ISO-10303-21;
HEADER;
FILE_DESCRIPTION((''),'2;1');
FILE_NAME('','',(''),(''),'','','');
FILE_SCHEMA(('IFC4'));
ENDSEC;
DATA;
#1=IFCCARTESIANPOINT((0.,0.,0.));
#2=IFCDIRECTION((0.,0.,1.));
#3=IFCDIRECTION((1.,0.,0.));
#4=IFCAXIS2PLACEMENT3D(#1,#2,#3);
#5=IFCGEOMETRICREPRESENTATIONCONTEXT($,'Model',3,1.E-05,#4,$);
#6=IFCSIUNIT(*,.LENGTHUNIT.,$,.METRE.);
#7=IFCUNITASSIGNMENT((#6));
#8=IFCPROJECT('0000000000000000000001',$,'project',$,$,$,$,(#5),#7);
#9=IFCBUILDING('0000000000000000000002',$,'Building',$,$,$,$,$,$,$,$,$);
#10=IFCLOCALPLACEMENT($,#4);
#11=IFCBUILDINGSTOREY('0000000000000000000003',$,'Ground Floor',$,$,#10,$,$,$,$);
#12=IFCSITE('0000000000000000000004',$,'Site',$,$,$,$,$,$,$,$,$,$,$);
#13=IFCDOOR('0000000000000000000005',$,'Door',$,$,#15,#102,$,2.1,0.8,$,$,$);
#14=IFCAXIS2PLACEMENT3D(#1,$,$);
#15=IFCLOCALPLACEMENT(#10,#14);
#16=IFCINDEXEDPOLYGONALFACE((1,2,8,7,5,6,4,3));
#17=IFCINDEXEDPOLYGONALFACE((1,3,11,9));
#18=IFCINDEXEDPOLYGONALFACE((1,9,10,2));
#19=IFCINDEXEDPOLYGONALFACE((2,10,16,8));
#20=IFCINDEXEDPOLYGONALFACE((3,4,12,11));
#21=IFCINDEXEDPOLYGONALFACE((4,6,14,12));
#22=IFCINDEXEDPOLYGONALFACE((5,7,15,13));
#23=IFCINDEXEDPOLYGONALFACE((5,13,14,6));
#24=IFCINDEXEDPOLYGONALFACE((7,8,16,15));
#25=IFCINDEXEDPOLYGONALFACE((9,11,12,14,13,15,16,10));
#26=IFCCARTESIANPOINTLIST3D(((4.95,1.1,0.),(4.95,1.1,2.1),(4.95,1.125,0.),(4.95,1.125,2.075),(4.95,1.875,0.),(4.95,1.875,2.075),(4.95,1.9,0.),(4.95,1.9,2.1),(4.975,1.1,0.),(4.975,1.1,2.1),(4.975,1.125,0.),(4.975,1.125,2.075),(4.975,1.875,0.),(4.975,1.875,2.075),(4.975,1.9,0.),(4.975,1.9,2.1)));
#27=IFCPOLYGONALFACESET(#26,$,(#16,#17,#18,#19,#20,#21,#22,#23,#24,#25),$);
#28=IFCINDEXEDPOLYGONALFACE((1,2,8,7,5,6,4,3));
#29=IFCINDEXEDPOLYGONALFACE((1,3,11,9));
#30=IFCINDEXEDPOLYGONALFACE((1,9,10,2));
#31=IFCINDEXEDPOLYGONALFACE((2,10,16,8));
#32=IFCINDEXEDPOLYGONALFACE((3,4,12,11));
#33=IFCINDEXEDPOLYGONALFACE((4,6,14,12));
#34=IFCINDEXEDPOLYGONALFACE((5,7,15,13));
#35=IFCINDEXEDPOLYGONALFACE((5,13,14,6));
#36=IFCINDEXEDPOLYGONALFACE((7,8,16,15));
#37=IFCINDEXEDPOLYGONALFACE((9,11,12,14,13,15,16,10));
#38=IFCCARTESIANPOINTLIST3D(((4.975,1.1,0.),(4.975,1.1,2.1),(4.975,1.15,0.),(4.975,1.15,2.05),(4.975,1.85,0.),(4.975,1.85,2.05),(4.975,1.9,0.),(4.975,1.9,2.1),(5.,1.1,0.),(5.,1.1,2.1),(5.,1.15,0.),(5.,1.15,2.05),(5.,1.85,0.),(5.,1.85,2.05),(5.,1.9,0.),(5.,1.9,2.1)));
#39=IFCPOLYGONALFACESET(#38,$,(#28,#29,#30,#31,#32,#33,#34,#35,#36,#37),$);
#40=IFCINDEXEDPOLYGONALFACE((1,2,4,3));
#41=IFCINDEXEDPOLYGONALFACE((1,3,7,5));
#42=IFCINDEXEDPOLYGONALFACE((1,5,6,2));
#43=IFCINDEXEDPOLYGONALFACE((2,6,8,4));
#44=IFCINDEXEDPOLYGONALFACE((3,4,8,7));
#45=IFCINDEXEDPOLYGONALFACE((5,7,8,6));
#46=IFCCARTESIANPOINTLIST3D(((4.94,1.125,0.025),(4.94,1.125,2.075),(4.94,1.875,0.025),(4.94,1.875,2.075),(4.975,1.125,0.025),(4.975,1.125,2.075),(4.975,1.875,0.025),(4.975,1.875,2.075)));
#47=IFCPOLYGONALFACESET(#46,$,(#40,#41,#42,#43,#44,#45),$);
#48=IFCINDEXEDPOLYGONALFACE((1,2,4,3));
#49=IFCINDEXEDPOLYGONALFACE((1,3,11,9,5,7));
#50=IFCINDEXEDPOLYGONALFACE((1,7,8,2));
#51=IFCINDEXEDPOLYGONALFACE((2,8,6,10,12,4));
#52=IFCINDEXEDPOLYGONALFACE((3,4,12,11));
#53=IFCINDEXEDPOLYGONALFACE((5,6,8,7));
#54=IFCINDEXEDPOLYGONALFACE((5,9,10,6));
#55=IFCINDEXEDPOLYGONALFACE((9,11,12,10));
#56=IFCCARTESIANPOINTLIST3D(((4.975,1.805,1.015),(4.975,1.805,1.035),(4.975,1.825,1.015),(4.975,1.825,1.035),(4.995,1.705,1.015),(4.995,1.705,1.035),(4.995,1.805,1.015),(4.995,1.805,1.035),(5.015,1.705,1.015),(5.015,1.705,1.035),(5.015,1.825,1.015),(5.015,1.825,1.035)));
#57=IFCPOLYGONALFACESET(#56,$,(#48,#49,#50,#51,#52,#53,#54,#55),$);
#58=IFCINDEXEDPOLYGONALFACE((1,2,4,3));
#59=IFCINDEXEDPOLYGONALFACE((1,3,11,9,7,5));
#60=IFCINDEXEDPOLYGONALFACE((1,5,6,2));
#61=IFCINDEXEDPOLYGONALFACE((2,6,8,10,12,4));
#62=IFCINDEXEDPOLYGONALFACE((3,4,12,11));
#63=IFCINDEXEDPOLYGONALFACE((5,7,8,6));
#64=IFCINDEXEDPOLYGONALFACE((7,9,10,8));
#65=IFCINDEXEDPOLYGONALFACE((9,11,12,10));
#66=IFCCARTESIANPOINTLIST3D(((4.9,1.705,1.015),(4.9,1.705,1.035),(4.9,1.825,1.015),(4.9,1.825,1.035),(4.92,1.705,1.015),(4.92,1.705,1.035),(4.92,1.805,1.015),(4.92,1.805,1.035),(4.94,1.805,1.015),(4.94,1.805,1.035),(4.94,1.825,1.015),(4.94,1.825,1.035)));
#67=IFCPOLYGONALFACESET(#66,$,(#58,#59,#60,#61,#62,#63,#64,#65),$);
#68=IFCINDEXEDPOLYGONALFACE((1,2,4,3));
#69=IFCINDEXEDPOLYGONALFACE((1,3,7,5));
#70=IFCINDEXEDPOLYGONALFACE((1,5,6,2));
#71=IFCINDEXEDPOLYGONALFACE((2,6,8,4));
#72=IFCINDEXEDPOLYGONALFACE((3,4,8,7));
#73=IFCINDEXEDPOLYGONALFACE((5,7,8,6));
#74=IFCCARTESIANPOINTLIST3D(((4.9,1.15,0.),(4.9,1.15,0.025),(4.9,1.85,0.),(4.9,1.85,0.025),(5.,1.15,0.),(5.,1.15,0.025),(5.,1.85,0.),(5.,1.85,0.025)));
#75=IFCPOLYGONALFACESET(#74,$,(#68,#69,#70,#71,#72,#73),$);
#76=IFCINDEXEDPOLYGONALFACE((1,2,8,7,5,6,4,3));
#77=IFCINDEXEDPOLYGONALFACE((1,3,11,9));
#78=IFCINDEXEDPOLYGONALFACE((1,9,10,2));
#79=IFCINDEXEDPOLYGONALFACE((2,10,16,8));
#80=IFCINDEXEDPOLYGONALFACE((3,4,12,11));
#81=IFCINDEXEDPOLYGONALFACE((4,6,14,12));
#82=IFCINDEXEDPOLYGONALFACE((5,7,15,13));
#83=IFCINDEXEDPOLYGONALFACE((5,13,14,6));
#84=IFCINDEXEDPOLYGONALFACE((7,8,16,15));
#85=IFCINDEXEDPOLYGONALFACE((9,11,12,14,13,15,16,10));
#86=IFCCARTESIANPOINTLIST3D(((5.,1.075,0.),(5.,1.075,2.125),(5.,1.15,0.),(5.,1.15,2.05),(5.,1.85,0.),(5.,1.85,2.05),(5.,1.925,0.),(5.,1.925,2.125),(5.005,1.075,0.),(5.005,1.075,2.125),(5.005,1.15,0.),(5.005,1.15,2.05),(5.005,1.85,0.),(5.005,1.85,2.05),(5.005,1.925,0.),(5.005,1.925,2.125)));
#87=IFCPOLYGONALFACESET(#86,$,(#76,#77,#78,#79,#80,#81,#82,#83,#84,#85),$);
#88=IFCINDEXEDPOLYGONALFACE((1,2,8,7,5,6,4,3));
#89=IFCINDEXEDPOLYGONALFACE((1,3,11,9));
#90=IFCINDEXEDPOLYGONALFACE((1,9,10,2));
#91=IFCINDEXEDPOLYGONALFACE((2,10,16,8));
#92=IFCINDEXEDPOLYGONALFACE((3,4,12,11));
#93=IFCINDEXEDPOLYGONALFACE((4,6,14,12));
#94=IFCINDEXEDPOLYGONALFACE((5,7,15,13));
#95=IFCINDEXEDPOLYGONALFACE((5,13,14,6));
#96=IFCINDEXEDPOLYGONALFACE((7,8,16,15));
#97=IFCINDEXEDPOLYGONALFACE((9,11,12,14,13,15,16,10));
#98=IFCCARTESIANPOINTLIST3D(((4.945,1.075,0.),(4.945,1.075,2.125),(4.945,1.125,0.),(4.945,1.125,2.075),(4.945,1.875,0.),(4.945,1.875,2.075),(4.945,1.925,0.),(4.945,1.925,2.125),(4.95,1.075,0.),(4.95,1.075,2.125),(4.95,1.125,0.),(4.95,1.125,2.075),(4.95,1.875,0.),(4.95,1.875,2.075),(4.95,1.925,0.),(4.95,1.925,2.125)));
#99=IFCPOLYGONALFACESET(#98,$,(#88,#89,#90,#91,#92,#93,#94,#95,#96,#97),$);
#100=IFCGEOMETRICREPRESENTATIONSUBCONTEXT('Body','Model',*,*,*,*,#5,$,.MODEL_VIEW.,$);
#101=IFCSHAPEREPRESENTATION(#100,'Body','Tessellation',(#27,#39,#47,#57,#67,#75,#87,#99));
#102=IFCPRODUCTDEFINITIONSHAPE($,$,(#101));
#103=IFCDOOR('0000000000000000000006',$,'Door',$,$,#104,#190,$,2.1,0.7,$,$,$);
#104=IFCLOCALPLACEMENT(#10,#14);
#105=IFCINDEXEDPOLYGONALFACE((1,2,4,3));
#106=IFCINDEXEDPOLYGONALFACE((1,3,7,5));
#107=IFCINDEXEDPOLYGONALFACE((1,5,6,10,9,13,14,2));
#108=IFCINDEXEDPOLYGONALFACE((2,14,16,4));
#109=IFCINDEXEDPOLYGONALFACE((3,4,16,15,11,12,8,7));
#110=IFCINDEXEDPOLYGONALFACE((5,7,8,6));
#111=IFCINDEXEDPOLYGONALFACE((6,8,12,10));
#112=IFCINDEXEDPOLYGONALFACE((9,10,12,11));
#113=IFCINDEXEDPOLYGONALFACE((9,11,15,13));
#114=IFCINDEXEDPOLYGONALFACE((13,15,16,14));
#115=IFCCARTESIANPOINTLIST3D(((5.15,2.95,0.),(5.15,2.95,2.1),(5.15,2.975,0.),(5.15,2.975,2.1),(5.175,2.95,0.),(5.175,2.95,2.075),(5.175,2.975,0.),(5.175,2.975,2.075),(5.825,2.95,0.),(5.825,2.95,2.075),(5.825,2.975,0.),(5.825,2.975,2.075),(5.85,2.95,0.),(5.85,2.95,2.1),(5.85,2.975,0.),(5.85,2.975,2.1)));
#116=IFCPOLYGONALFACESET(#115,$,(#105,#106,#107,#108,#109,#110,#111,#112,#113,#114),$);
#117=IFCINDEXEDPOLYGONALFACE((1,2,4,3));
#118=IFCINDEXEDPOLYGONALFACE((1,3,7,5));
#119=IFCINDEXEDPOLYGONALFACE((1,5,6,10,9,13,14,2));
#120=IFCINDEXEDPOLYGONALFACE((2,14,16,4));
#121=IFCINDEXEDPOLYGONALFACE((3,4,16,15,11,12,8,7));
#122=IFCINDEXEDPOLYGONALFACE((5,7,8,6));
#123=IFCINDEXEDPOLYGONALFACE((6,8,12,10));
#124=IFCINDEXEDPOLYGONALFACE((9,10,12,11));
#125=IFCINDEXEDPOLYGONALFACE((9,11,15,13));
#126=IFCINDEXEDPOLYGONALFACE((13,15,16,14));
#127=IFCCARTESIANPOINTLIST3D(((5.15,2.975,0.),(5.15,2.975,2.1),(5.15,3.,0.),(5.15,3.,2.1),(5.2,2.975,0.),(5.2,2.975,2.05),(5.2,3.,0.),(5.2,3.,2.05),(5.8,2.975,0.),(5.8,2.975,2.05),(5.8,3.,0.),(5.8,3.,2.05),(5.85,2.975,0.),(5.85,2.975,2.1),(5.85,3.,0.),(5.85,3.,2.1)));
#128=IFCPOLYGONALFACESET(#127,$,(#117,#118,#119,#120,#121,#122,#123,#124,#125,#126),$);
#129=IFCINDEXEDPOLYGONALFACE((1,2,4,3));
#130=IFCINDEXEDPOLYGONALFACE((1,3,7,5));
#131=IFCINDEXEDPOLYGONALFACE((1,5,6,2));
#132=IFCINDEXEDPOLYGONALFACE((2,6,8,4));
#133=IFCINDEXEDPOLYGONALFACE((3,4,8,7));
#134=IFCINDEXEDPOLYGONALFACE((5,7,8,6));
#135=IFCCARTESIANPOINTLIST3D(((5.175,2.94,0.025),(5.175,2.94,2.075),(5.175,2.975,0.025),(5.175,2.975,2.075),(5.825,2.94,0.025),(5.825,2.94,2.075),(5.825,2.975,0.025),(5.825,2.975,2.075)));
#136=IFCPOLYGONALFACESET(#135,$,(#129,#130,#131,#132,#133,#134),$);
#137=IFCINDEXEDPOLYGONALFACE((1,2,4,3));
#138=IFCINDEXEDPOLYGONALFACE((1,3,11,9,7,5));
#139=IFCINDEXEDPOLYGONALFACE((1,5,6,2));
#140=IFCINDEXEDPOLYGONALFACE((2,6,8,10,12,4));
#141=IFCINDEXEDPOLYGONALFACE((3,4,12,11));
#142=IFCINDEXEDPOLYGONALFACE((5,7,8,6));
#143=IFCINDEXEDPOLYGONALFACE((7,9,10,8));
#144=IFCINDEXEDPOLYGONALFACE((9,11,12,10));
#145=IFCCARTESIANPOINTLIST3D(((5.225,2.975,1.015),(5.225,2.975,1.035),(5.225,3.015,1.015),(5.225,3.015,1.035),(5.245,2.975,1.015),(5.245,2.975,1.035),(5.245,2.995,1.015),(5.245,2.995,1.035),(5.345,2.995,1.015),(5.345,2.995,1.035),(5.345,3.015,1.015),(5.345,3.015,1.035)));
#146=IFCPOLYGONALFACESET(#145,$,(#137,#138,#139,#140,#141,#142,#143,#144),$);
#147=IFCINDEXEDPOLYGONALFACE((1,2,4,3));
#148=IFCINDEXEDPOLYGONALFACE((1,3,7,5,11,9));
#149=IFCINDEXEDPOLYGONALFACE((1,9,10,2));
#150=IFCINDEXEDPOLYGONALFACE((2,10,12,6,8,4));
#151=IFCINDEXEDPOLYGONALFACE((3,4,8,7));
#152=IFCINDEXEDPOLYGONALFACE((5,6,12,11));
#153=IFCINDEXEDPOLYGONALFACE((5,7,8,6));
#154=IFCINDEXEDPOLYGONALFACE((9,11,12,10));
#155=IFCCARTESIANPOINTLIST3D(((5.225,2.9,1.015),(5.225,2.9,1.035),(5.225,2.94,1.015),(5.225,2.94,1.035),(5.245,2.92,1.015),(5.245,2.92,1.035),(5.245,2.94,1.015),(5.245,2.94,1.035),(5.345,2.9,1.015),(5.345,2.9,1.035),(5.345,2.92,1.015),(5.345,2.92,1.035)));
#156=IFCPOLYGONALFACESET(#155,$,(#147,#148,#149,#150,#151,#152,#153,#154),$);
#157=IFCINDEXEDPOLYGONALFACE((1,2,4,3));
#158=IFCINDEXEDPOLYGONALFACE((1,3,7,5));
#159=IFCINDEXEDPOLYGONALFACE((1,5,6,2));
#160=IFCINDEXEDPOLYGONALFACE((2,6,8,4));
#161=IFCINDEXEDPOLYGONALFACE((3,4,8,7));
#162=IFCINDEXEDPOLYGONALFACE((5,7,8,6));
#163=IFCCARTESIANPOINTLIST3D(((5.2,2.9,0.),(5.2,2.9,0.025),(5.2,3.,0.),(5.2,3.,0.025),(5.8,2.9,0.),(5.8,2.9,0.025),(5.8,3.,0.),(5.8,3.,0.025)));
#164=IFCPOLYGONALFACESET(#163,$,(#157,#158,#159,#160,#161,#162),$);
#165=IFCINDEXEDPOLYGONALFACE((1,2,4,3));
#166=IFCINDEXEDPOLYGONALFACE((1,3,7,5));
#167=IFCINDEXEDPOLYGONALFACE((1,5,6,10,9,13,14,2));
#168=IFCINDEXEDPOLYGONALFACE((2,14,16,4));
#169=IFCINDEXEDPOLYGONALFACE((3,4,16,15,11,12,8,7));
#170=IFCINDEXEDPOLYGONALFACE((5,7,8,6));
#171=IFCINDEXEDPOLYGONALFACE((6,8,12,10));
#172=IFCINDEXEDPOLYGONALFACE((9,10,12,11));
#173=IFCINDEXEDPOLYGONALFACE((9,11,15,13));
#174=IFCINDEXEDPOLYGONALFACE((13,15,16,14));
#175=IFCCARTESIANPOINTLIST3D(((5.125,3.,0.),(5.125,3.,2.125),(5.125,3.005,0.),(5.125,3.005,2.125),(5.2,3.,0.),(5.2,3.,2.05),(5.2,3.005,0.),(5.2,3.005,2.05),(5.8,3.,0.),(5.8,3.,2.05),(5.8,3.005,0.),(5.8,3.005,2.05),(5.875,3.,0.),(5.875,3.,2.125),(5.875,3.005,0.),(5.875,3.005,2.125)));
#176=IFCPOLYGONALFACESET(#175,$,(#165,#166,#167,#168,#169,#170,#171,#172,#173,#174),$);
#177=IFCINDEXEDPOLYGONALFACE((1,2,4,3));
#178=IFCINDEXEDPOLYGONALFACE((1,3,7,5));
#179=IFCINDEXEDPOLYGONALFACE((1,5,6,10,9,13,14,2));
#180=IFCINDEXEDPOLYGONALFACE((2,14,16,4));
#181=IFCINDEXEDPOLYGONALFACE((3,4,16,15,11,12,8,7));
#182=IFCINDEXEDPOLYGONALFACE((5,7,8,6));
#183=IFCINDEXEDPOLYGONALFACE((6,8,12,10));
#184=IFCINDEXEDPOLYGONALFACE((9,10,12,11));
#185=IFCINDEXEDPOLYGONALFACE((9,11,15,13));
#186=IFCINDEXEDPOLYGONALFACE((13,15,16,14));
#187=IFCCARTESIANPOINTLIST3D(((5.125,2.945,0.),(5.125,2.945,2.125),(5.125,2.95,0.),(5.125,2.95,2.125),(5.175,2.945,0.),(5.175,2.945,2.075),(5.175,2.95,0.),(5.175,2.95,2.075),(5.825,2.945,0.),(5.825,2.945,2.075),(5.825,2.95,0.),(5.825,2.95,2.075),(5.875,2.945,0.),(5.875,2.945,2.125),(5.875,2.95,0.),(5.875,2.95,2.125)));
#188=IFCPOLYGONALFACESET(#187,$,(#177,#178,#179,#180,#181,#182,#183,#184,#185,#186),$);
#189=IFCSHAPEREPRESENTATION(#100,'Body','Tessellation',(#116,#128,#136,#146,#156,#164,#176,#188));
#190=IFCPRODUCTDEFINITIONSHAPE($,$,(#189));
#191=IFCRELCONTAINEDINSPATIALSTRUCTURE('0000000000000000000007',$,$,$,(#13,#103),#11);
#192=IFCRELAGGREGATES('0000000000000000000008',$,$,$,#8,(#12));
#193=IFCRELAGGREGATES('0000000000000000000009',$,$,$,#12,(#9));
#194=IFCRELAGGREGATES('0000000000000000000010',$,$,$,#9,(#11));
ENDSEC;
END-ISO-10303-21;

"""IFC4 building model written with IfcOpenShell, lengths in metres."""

from ifc_helpers import new_model, si_unit, frame, origin_with_axes, place, context, subcontext, project, spatial, line, indexed_curve, outline, extrude, element, save


model = new_model("IFC4")

# Units and contexts
model_context = context("Model", 3, precision=1e-05, world=origin_with_axes())
body_context = subcontext(model_context, "Body", "Model", "MODEL_VIEW")
ifc_project = project(units=[si_unit("LENGTHUNIT", "METRE")], contexts=[model_context])

# Site, building, storey
site = spatial("IfcSite", under=ifc_project, Name="Site")
building = spatial("IfcBuilding", under=site, Name="Building")
storey_placement = place(None, origin_with_axes())
storey = spatial("IfcBuildingStorey", under=building, at=storey_placement, Name="Ground Floor")

# Doors
door_1_placement = place(storey_placement, frame((5.0, 1.1, 0.0), z_axis=(0.0, 0.0, 1.0), x_axis=(0.0, 1.0, 0.0)))
element("IfcDoor", 1, at=door_1_placement, inside=storey, Name="Door", OverallHeight=2.1, OverallWidth=0.8, context=body_context, shape_type="SweptSolid", body=[
    extrude(outline(indexed_curve([(0.0, 0.0), (0.0, 2.1), (0.8, 2.1), (0.8, 0.0), (0.775, 0.0), (0.775, 2.075), (0.025, 2.075), (0.025, 0.0)], segments=[line(1, 2, 3, 4, 5, 6, 7, 8, 1)])), frame((0.0, 0.025, 0.0), z_axis=(0.0, -1.0, 0.0), x_axis=(1.0, 0.0, 0.0)), (0.0, 0.0, -1.0), 0.025),
    extrude(outline(indexed_curve([(0.0, 0.0), (0.0, 2.1), (0.8, 2.1), (0.8, 0.0), (0.75, 0.0), (0.75, 2.05), (0.05, 2.05), (0.05, 0.0)], segments=[line(1, 2, 3, 4, 5, 6, 7, 8, 1)])), frame((0.0, 0.0, 0.0), z_axis=(0.0, -1.0, 0.0), x_axis=(1.0, 0.0, 0.0)), (0.0, 0.0, -1.0), 0.025),
    extrude(outline(indexed_curve([(0.0, 0.0), (0.75, 0.0), (0.75, 0.035), (0.0, 0.035)], segments=[line(1, 2, 3, 4, 1)])), frame((0.025, 0.025, 0.025), z_axis=(0.0, 0.0, 1.0), x_axis=(1.0, 0.0, 0.0)), (0.0, 0.0, 1.0), 2.05),
    extrude(outline(indexed_curve([(0.0, 0.0), (0.0, -0.04), (-0.12, -0.04), (-0.12, -0.02), (-0.02, -0.02), (-0.02, 0.0)], segments=[line(1, 2, 3, 4, 5, 6, 1)])), frame((0.725, 0.025, 1.015), z_axis=(0.0, 0.0, 1.0), x_axis=(1.0, 0.0, 0.0)), (0.0, 0.0, 1.0), 0.02),
    extrude(outline(indexed_curve([(0.0, 0.0), (0.0, 0.04), (-0.12, 0.04), (-0.12, 0.02), (-0.02, 0.02), (-0.02, 0.0)], segments=[line(1, 2, 3, 4, 5, 6, 1)])), frame((0.725, 0.06, 1.015), z_axis=(0.0, 0.0, 1.0), x_axis=(1.0, 0.0, 0.0)), (0.0, 0.0, 1.0), 0.02),
    extrude(outline(indexed_curve([(0.0, 0.0), (0.7, 0.0), (0.7, 0.1), (0.0, 0.1)], segments=[line(1, 2, 3, 4, 1)])), frame((0.05, 0.0, 0.0), z_axis=(0.0, 0.0, 1.0), x_axis=(1.0, 0.0, 0.0)), (0.0, 0.0, 1.0), 0.025),
    extrude(outline(indexed_curve([(0.0, 0.0), (0.0, 2.125), (0.85, 2.125), (0.85, 0.0), (0.775, 0.0), (0.775, 2.05), (0.075, 2.05), (0.075, 0.0)], segments=[line(1, 2, 3, 4, 5, 6, 7, 8, 1)])), frame((-0.025, -0.005, 0.0), z_axis=(0.0, -1.0, 0.0), x_axis=(1.0, 0.0, 0.0)), (0.0, 0.0, -1.0), 0.005),
    extrude(outline(indexed_curve([(0.0, 0.0), (0.0, 2.125), (0.85, 2.125), (0.85, 0.0), (0.8, 0.0), (0.8, 2.075), (0.05, 2.075), (0.05, 0.0)], segments=[line(1, 2, 3, 4, 5, 6, 7, 8, 1)])), frame((-0.025, 0.05, 0.0), z_axis=(0.0, -1.0, 0.0), x_axis=(1.0, 0.0, 0.0)), (0.0, 0.0, -1.0), 0.005),
])
door_2_placement = place(storey_placement, frame((5.85, 3.0, 0.0), z_axis=(0.0, 0.0, 1.0), x_axis=(-1.0, 0.0, 0.0)))
element("IfcDoor", 2, at=door_2_placement, inside=storey, Name="Door", OverallHeight=2.1, OverallWidth=0.7, context=body_context, shape_type="SweptSolid", body=[
    extrude(outline(indexed_curve([(0.0, 0.0), (0.0, 2.1), (0.7, 2.1), (0.7, 0.0), (0.675, 0.0), (0.675, 2.075), (0.025, 2.075), (0.025, 0.0)], segments=[line(1, 2, 3, 4, 5, 6, 7, 8, 1)])), frame((0.0, 0.025, 0.0), z_axis=(0.0, -1.0, 0.0), x_axis=(1.0, 0.0, 0.0)), (0.0, 0.0, -1.0), 0.025),
    extrude(outline(indexed_curve([(0.0, 0.0), (0.0, 2.1), (0.7, 2.1), (0.7, 0.0), (0.65, 0.0), (0.65, 2.05), (0.05, 2.05), (0.05, 0.0)], segments=[line(1, 2, 3, 4, 5, 6, 7, 8, 1)])), frame((0.0, 0.0, 0.0), z_axis=(0.0, -1.0, 0.0), x_axis=(1.0, 0.0, 0.0)), (0.0, 0.0, -1.0), 0.025),
    extrude(outline(indexed_curve([(0.0, 0.0), (0.65, 0.0), (0.65, 0.035), (0.0, 0.035)], segments=[line(1, 2, 3, 4, 1)])), frame((0.025, 0.025, 0.025), z_axis=(0.0, 0.0, 1.0), x_axis=(1.0, 0.0, 0.0)), (0.0, 0.0, 1.0), 2.05),
    extrude(outline(indexed_curve([(0.0, 0.0), (0.0, -0.04), (-0.12, -0.04), (-0.12, -0.02), (-0.02, -0.02), (-0.02, 0.0)], segments=[line(1, 2, 3, 4, 5, 6, 1)])), frame((0.625, 0.025, 1.015), z_axis=(0.0, 0.0, 1.0), x_axis=(1.0, 0.0, 0.0)), (0.0, 0.0, 1.0), 0.02),
    extrude(outline(indexed_curve([(0.0, 0.0), (0.0, 0.04), (-0.12, 0.04), (-0.12, 0.02), (-0.02, 0.02), (-0.02, 0.0)], segments=[line(1, 2, 3, 4, 5, 6, 1)])), frame((0.625, 0.06, 1.015), z_axis=(0.0, 0.0, 1.0), x_axis=(1.0, 0.0, 0.0)), (0.0, 0.0, 1.0), 0.02),
    extrude(outline(indexed_curve([(0.0, 0.0), (0.6, 0.0), (0.6, 0.1), (0.0, 0.1)], segments=[line(1, 2, 3, 4, 1)])), frame((0.05, 0.0, 0.0), z_axis=(0.0, 0.0, 1.0), x_axis=(1.0, 0.0, 0.0)), (0.0, 0.0, 1.0), 0.025),
    extrude(outline(indexed_curve([(0.0, 0.0), (0.0, 2.125), (0.75, 2.125), (0.75, 0.0), (0.675, 0.0), (0.675, 2.05), (0.075, 2.05), (0.075, 0.0)], segments=[line(1, 2, 3, 4, 5, 6, 7, 8, 1)])), frame((-0.025, -0.005, 0.0), z_axis=(0.0, -1.0, 0.0), x_axis=(1.0, 0.0, 0.0)), (0.0, 0.0, -1.0), 0.005),
    extrude(outline(indexed_curve([(0.0, 0.0), (0.0, 2.125), (0.75, 2.125), (0.75, 0.0), (0.7, 0.0), (0.7, 2.075), (0.05, 2.075), (0.05, 0.0)], segments=[line(1, 2, 3, 4, 5, 6, 7, 8, 1)])), frame((-0.025, 0.05, 0.0), z_axis=(0.0, -1.0, 0.0), x_axis=(1.0, 0.0, 0.0)), (0.0, 0.0, -1.0), 0.005),
])

save(model, "model.ifc")
